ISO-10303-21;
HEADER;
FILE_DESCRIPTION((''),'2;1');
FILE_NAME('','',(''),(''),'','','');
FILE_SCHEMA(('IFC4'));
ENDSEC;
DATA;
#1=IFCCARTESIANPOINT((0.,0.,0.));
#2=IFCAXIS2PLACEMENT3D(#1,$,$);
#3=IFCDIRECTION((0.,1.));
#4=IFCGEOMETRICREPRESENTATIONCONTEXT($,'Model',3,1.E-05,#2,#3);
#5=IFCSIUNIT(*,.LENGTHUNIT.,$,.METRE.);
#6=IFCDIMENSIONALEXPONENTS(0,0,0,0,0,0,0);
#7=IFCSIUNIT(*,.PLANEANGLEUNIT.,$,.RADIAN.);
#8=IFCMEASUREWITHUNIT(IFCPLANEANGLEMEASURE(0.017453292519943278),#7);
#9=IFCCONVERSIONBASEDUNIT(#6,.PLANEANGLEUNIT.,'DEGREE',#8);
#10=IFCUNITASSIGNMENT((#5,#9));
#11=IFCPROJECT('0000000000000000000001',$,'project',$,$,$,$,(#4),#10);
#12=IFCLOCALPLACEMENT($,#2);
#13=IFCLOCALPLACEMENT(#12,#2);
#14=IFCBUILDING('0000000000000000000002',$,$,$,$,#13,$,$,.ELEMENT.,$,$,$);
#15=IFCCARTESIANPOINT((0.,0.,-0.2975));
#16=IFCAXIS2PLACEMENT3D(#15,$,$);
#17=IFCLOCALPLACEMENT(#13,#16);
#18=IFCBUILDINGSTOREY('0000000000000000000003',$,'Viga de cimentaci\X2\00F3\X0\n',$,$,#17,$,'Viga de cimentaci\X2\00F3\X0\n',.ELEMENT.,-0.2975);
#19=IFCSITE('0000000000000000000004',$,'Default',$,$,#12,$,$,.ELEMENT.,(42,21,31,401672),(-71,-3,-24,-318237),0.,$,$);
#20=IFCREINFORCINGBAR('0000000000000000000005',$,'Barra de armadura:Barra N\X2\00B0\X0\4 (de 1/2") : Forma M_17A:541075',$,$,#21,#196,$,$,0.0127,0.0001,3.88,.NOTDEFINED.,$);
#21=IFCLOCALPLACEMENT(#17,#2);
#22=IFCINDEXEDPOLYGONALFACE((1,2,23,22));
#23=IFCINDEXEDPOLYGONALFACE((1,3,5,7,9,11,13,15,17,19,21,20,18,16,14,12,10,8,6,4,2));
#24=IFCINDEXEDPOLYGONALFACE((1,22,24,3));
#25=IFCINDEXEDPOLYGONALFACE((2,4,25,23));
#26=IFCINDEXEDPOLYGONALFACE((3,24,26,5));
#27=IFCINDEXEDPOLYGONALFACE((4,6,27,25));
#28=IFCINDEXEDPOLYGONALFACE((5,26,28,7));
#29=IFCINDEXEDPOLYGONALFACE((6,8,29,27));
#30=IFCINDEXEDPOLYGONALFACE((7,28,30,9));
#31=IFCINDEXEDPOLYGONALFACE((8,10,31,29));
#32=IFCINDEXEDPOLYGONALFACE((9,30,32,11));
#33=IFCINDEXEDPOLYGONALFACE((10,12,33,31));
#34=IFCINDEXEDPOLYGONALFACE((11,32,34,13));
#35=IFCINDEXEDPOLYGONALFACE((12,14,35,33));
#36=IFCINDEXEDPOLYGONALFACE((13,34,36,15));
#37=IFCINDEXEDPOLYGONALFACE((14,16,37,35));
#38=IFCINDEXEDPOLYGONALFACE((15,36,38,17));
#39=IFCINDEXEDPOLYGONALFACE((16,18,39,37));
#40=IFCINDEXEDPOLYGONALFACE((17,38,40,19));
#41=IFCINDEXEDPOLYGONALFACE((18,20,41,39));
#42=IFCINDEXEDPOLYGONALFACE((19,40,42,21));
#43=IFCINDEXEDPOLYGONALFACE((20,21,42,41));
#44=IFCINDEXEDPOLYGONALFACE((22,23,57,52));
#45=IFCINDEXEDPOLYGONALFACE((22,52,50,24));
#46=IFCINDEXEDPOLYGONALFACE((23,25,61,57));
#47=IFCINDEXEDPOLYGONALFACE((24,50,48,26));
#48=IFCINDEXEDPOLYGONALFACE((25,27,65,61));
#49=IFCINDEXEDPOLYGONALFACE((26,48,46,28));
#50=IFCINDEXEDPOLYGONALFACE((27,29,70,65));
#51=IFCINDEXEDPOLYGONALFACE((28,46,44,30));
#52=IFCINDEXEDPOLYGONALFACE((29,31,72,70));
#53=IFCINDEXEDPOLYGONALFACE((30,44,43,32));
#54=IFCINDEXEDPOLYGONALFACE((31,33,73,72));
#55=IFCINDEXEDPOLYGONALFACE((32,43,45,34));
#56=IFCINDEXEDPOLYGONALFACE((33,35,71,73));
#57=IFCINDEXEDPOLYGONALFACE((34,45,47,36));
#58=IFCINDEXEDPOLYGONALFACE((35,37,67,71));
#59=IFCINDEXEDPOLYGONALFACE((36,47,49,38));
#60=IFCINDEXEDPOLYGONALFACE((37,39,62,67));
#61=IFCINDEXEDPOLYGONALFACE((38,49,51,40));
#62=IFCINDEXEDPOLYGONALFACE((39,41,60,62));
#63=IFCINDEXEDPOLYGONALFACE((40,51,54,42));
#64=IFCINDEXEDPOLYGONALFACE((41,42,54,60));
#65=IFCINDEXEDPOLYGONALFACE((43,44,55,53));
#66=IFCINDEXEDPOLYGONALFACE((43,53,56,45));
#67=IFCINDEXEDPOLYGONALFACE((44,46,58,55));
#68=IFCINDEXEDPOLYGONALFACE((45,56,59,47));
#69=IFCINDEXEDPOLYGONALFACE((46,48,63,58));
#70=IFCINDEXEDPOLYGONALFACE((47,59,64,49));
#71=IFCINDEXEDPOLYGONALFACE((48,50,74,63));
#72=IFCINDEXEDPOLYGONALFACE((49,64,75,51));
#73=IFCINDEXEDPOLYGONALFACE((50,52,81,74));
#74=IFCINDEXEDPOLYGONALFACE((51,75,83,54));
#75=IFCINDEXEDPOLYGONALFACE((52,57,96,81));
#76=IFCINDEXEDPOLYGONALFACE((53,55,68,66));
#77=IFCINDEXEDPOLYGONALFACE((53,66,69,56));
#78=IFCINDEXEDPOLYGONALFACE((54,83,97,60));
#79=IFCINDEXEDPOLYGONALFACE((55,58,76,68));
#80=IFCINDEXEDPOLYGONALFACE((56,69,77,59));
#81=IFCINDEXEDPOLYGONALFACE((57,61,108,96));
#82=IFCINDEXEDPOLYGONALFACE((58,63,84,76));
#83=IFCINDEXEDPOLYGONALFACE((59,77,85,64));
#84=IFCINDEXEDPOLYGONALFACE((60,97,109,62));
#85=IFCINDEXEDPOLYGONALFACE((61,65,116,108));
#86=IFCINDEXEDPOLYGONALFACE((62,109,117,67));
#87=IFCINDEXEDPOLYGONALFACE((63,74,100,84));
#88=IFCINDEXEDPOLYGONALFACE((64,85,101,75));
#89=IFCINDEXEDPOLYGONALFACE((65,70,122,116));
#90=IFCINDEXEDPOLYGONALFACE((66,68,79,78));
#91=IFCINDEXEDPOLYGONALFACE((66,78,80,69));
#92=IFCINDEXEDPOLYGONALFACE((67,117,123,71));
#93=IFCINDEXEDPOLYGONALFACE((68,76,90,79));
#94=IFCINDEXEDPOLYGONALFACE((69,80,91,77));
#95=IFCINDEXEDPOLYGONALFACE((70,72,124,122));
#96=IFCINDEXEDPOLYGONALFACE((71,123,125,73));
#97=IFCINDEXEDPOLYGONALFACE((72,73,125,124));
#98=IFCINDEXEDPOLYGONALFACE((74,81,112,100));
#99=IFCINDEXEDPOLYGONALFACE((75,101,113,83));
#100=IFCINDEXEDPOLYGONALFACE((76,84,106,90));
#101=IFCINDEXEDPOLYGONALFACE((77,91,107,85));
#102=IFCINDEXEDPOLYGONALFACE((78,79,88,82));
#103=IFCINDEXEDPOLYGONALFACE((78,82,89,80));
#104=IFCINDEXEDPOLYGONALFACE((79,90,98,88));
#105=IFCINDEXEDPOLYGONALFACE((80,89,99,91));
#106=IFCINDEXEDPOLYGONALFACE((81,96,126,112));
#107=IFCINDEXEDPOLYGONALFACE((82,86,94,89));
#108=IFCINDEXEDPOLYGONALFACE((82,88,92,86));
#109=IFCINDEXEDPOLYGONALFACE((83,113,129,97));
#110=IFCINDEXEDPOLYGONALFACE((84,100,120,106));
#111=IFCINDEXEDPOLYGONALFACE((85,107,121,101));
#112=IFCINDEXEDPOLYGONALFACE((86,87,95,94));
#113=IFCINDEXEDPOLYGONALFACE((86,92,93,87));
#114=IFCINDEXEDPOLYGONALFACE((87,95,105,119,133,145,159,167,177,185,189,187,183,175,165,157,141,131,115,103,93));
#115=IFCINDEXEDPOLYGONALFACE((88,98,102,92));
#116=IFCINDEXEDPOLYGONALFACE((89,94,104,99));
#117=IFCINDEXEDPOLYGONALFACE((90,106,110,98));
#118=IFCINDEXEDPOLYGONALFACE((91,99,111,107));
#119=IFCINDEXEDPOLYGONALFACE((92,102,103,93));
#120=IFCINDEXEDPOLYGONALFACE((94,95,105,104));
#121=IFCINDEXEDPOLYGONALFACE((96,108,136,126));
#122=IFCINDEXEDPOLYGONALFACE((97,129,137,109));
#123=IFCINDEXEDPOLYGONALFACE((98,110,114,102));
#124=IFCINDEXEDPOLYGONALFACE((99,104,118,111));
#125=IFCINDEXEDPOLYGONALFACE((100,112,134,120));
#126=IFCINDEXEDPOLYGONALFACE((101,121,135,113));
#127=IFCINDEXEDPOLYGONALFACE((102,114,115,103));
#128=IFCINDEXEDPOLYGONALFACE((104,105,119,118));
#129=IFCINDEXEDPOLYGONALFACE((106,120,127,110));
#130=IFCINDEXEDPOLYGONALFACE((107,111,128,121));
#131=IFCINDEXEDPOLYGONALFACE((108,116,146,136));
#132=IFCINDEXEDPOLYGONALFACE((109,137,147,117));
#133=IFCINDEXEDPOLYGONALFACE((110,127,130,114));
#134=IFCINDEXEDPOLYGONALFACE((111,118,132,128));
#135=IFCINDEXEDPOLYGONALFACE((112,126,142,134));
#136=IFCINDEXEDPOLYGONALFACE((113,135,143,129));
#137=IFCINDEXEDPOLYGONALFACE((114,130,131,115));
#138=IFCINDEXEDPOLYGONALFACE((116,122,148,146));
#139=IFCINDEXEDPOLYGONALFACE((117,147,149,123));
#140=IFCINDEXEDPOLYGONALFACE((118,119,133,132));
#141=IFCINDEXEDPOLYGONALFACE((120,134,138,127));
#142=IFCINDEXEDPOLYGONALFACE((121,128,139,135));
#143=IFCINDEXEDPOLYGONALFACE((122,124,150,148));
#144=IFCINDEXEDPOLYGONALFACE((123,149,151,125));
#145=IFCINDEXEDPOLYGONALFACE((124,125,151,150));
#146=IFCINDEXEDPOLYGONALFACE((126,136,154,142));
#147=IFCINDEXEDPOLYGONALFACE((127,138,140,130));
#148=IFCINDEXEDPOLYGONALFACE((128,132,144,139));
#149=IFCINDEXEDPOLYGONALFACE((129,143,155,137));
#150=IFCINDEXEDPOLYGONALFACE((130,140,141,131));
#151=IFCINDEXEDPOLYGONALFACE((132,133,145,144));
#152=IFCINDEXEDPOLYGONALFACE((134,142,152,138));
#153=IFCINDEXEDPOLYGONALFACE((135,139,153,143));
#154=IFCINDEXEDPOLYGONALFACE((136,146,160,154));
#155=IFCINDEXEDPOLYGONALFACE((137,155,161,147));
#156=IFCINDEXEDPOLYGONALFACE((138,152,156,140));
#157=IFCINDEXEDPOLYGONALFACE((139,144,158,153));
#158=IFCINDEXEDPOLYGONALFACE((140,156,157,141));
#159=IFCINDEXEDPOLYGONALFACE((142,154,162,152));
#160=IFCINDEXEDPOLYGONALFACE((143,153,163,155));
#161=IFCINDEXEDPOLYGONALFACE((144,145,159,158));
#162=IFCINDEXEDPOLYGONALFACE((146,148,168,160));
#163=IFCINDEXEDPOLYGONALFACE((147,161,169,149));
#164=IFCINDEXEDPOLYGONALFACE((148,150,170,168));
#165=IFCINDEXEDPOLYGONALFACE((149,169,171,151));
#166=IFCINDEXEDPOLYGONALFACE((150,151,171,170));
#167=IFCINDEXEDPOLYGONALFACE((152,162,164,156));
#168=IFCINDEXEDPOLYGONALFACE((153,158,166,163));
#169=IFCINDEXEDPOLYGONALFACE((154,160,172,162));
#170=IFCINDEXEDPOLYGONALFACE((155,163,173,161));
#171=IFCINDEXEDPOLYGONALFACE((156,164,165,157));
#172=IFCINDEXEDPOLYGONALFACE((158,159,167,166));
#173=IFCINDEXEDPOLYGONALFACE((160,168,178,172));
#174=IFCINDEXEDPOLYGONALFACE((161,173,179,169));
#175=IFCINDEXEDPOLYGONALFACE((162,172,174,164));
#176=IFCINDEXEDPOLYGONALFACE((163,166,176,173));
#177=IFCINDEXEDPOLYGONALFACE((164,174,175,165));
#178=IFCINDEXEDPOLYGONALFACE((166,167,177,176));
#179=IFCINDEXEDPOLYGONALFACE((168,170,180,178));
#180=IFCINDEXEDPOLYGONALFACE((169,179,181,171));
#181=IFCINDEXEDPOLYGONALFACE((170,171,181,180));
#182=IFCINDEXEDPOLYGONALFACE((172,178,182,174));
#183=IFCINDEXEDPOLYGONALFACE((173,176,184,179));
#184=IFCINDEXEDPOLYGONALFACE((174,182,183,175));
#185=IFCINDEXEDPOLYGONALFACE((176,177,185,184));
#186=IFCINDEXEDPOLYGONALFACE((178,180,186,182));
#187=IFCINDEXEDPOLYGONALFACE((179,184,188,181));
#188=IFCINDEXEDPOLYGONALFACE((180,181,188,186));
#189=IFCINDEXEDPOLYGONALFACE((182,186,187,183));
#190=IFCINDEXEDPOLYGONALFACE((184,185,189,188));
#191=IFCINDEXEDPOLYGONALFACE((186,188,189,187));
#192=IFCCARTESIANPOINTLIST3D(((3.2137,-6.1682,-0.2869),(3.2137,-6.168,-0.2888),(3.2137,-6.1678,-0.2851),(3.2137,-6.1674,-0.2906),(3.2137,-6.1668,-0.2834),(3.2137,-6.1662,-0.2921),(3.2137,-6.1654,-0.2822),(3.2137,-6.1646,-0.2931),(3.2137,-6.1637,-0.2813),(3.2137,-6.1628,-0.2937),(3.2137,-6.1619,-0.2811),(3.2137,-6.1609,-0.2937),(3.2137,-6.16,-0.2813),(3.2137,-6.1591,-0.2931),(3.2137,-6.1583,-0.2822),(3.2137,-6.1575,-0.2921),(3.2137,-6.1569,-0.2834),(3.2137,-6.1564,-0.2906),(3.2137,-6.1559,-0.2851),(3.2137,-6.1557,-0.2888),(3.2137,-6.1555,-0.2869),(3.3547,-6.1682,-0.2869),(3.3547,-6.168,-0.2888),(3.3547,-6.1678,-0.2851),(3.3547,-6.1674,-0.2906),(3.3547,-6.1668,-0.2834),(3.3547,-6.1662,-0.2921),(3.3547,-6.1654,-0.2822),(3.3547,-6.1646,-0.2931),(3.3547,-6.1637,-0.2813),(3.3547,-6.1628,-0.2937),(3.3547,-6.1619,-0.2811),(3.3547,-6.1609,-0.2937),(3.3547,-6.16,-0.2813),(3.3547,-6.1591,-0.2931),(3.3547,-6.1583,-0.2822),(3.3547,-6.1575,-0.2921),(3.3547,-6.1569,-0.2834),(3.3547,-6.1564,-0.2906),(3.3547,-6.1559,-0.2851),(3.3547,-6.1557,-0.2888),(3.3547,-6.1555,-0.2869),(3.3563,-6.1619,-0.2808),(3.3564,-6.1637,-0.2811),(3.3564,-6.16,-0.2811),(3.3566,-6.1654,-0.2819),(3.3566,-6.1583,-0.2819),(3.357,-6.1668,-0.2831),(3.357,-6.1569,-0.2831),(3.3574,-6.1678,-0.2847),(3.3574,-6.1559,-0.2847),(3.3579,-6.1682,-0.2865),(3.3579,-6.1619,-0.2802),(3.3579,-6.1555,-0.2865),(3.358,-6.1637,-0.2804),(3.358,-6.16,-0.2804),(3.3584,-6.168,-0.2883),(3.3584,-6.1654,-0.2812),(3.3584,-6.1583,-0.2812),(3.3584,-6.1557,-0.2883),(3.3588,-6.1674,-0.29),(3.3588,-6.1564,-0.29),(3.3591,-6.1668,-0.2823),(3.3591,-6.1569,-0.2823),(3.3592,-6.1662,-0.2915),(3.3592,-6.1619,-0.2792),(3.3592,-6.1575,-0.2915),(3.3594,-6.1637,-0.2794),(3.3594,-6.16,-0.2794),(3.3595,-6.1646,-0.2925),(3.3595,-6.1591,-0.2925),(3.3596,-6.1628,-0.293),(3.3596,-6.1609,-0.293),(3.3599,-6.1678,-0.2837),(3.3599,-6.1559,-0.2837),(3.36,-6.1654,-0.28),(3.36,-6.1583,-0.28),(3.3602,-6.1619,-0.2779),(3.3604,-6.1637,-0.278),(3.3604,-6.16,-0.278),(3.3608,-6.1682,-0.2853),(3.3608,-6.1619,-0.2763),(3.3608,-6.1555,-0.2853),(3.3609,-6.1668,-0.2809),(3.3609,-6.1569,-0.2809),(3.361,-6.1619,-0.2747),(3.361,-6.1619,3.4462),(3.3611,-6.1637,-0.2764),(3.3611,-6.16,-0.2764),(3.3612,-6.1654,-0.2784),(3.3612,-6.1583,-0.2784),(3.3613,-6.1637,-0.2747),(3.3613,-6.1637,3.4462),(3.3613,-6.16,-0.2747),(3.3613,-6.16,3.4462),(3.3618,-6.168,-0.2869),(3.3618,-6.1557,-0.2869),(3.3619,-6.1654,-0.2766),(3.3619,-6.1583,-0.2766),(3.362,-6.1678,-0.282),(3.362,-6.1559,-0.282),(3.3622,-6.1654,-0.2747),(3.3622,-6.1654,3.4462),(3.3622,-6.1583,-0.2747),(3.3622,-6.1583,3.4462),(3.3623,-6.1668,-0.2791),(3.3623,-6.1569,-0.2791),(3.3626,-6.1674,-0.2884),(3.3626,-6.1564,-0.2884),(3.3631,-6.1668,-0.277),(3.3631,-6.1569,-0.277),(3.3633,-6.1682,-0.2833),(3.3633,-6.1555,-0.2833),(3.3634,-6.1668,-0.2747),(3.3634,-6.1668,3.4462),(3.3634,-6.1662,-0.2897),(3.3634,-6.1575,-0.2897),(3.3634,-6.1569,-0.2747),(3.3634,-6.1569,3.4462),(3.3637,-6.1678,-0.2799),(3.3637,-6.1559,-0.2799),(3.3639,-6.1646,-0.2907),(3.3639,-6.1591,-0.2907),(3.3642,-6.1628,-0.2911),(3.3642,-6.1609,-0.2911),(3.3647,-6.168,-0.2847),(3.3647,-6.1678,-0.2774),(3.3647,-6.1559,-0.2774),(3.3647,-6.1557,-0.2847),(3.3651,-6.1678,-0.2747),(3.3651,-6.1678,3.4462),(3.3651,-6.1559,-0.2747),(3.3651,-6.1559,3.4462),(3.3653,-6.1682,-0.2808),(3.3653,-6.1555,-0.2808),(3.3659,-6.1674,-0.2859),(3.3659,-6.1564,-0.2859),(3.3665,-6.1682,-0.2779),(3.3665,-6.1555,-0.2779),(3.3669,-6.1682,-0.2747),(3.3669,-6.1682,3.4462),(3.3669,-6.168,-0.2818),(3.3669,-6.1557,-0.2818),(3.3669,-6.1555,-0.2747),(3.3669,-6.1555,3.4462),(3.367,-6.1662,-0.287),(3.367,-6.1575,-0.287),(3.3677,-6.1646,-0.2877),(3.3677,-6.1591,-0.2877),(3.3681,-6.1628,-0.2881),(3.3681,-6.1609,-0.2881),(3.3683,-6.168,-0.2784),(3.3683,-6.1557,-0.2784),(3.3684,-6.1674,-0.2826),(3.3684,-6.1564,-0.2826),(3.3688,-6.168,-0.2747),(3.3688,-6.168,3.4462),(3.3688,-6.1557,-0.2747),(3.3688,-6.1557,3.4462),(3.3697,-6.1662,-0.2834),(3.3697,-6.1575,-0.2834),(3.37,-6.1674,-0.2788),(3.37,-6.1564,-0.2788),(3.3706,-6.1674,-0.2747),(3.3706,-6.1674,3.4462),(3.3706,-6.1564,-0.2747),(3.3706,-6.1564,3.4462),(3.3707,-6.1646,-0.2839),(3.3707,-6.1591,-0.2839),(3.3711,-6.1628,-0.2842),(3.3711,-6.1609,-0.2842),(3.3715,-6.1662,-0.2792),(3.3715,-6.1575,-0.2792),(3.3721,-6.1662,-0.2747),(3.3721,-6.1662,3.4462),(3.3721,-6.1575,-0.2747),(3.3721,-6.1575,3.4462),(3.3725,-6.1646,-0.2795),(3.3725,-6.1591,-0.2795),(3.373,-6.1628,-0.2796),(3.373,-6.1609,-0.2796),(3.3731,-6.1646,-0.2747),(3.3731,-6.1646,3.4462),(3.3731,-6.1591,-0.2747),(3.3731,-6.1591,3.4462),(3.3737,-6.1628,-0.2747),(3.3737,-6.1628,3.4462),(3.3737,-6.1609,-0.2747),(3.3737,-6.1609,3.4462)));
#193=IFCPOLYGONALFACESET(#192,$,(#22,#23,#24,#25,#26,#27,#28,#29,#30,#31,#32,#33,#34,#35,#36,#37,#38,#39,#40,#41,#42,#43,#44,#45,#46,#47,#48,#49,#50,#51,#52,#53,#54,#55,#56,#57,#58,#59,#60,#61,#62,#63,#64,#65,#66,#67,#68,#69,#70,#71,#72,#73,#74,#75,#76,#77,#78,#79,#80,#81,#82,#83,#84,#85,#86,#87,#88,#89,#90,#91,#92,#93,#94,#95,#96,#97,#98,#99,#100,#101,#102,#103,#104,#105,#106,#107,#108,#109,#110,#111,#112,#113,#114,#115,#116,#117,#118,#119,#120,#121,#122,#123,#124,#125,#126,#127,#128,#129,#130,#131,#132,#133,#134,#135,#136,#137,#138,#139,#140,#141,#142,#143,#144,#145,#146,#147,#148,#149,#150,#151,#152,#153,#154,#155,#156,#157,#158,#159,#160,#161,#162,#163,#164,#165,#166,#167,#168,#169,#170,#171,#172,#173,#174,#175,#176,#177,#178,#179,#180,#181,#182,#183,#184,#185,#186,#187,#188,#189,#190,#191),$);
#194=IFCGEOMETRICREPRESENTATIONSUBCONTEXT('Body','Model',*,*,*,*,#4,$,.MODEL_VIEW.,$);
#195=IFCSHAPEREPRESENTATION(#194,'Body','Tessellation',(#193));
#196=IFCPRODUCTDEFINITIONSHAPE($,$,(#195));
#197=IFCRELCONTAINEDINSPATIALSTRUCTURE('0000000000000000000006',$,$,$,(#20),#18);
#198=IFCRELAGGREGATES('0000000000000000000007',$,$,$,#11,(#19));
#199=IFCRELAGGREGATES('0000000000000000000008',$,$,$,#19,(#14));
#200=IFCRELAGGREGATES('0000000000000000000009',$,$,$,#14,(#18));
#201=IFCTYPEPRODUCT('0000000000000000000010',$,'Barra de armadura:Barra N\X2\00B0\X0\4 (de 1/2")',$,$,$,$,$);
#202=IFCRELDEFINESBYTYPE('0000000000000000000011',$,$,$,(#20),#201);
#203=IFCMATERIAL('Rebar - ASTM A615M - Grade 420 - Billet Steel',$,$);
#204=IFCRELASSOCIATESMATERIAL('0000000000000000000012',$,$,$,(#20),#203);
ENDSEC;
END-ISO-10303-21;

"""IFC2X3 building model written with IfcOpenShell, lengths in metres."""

from ifc_helpers import new_model, entity, si_unit, converted_unit, direction, frame, origin, place, context, subcontext, project, spatial, material, type_object, element, save


model = new_model("IFC2X3")

# Units and contexts
model_context = context("Model", 3, precision=1e-05, world=origin(), true_north=direction((0.0, 1.0)))
body_context = subcontext(model_context, "Body", "Model", "MODEL_VIEW")
ifc_project = project(units=[si_unit("LENGTHUNIT", "METRE"), converted_unit("PLANEANGLEUNIT", "DEGREE", entity("IfcPlaneAngleMeasure", 0.017453292519943278), si_unit("PLANEANGLEUNIT", "RADIAN"), dimensions=[0, 0, 0, 0, 0, 0, 0])], contexts=[model_context])

# Site, building, storey
site_placement = place(None, origin())
site = spatial("IfcSite", under=ifc_project, at=site_placement, Name="Default", CompositionType="ELEMENT", RefLatitude=(42, 21, 31, 401672), RefLongitude=(-71, -3, -24, -318237), RefElevation=0.0)
building_placement = place(site_placement, origin())
building = spatial("IfcBuilding", under=site, at=building_placement, CompositionType="ELEMENT")
storey_placement = place(building_placement, frame((0.0, 0.0, -0.2975)))
storey = spatial("IfcBuildingStorey", under=building, at=storey_placement, Name="Viga de cimentación", LongName="Viga de cimentación", CompositionType="ELEMENT", Elevation=-0.2975)

# Reinforcing bar
ifc_material_1 = material(Name="Rebar - ASTM A615M - Grade 420 - Billet Steel")
type_product_1 = type_object("IfcTypeProduct", Name="Barra de armadura:Barra N°4 (de 1/2\")")
reinforcing_bar_1_placement = place(storey_placement, origin())
element("IfcReinforcingBar", 1, at=reinforcing_bar_1_placement, inside=storey, type_object=type_product_1, material=ifc_material_1, Name="Barra de armadura:Barra N°4 (de 1/2\") : Forma M_17A:541075", BarLength=3.88, BarRole="NOTDEFINED", CrossSectionArea=0.0001, NominalDiameter=0.0127, context=body_context, shape_type="AdvancedSweptSolid", body=[
    entity("IfcSweptDiskSolid", entity("IfcCompositeCurve", [entity("IfcCompositeCurveSegment", "CONTINUOUS", True, entity("IfcPolyline", [entity("IfcCartesianPoint", [3.3674, -6.1619, 3.4462]), entity("IfcCartesianPoint", [3.3674, -6.1619, -0.2747])])), entity("IfcCompositeCurveSegment", "CONTINUOUS", True, entity("IfcTrimmedCurve", entity("IfcCircle", entity("IfcAxis2Placement3D", entity("IfcCartesianPoint", [3.3547, -6.1619, -0.2747]), entity("IfcDirection", [0.0, 1.0, 0.0]), entity("IfcDirection", [0.0, 0.0, -1.0])), 0.0127), [entity("IfcParameterValue", 270.0)], [entity("IfcParameterValue", 360.0)], True, "PARAMETER")), entity("IfcCompositeCurveSegment", "CONTINUOUS", True, entity("IfcPolyline", [entity("IfcCartesianPoint", [3.3547, -6.1619, -0.2874]), entity("IfcCartesianPoint", [3.2137, -6.1619, -0.2874])]))], False), 0.0063, None, 0.0, 92.0),
])

save(model, "model.ifc")
